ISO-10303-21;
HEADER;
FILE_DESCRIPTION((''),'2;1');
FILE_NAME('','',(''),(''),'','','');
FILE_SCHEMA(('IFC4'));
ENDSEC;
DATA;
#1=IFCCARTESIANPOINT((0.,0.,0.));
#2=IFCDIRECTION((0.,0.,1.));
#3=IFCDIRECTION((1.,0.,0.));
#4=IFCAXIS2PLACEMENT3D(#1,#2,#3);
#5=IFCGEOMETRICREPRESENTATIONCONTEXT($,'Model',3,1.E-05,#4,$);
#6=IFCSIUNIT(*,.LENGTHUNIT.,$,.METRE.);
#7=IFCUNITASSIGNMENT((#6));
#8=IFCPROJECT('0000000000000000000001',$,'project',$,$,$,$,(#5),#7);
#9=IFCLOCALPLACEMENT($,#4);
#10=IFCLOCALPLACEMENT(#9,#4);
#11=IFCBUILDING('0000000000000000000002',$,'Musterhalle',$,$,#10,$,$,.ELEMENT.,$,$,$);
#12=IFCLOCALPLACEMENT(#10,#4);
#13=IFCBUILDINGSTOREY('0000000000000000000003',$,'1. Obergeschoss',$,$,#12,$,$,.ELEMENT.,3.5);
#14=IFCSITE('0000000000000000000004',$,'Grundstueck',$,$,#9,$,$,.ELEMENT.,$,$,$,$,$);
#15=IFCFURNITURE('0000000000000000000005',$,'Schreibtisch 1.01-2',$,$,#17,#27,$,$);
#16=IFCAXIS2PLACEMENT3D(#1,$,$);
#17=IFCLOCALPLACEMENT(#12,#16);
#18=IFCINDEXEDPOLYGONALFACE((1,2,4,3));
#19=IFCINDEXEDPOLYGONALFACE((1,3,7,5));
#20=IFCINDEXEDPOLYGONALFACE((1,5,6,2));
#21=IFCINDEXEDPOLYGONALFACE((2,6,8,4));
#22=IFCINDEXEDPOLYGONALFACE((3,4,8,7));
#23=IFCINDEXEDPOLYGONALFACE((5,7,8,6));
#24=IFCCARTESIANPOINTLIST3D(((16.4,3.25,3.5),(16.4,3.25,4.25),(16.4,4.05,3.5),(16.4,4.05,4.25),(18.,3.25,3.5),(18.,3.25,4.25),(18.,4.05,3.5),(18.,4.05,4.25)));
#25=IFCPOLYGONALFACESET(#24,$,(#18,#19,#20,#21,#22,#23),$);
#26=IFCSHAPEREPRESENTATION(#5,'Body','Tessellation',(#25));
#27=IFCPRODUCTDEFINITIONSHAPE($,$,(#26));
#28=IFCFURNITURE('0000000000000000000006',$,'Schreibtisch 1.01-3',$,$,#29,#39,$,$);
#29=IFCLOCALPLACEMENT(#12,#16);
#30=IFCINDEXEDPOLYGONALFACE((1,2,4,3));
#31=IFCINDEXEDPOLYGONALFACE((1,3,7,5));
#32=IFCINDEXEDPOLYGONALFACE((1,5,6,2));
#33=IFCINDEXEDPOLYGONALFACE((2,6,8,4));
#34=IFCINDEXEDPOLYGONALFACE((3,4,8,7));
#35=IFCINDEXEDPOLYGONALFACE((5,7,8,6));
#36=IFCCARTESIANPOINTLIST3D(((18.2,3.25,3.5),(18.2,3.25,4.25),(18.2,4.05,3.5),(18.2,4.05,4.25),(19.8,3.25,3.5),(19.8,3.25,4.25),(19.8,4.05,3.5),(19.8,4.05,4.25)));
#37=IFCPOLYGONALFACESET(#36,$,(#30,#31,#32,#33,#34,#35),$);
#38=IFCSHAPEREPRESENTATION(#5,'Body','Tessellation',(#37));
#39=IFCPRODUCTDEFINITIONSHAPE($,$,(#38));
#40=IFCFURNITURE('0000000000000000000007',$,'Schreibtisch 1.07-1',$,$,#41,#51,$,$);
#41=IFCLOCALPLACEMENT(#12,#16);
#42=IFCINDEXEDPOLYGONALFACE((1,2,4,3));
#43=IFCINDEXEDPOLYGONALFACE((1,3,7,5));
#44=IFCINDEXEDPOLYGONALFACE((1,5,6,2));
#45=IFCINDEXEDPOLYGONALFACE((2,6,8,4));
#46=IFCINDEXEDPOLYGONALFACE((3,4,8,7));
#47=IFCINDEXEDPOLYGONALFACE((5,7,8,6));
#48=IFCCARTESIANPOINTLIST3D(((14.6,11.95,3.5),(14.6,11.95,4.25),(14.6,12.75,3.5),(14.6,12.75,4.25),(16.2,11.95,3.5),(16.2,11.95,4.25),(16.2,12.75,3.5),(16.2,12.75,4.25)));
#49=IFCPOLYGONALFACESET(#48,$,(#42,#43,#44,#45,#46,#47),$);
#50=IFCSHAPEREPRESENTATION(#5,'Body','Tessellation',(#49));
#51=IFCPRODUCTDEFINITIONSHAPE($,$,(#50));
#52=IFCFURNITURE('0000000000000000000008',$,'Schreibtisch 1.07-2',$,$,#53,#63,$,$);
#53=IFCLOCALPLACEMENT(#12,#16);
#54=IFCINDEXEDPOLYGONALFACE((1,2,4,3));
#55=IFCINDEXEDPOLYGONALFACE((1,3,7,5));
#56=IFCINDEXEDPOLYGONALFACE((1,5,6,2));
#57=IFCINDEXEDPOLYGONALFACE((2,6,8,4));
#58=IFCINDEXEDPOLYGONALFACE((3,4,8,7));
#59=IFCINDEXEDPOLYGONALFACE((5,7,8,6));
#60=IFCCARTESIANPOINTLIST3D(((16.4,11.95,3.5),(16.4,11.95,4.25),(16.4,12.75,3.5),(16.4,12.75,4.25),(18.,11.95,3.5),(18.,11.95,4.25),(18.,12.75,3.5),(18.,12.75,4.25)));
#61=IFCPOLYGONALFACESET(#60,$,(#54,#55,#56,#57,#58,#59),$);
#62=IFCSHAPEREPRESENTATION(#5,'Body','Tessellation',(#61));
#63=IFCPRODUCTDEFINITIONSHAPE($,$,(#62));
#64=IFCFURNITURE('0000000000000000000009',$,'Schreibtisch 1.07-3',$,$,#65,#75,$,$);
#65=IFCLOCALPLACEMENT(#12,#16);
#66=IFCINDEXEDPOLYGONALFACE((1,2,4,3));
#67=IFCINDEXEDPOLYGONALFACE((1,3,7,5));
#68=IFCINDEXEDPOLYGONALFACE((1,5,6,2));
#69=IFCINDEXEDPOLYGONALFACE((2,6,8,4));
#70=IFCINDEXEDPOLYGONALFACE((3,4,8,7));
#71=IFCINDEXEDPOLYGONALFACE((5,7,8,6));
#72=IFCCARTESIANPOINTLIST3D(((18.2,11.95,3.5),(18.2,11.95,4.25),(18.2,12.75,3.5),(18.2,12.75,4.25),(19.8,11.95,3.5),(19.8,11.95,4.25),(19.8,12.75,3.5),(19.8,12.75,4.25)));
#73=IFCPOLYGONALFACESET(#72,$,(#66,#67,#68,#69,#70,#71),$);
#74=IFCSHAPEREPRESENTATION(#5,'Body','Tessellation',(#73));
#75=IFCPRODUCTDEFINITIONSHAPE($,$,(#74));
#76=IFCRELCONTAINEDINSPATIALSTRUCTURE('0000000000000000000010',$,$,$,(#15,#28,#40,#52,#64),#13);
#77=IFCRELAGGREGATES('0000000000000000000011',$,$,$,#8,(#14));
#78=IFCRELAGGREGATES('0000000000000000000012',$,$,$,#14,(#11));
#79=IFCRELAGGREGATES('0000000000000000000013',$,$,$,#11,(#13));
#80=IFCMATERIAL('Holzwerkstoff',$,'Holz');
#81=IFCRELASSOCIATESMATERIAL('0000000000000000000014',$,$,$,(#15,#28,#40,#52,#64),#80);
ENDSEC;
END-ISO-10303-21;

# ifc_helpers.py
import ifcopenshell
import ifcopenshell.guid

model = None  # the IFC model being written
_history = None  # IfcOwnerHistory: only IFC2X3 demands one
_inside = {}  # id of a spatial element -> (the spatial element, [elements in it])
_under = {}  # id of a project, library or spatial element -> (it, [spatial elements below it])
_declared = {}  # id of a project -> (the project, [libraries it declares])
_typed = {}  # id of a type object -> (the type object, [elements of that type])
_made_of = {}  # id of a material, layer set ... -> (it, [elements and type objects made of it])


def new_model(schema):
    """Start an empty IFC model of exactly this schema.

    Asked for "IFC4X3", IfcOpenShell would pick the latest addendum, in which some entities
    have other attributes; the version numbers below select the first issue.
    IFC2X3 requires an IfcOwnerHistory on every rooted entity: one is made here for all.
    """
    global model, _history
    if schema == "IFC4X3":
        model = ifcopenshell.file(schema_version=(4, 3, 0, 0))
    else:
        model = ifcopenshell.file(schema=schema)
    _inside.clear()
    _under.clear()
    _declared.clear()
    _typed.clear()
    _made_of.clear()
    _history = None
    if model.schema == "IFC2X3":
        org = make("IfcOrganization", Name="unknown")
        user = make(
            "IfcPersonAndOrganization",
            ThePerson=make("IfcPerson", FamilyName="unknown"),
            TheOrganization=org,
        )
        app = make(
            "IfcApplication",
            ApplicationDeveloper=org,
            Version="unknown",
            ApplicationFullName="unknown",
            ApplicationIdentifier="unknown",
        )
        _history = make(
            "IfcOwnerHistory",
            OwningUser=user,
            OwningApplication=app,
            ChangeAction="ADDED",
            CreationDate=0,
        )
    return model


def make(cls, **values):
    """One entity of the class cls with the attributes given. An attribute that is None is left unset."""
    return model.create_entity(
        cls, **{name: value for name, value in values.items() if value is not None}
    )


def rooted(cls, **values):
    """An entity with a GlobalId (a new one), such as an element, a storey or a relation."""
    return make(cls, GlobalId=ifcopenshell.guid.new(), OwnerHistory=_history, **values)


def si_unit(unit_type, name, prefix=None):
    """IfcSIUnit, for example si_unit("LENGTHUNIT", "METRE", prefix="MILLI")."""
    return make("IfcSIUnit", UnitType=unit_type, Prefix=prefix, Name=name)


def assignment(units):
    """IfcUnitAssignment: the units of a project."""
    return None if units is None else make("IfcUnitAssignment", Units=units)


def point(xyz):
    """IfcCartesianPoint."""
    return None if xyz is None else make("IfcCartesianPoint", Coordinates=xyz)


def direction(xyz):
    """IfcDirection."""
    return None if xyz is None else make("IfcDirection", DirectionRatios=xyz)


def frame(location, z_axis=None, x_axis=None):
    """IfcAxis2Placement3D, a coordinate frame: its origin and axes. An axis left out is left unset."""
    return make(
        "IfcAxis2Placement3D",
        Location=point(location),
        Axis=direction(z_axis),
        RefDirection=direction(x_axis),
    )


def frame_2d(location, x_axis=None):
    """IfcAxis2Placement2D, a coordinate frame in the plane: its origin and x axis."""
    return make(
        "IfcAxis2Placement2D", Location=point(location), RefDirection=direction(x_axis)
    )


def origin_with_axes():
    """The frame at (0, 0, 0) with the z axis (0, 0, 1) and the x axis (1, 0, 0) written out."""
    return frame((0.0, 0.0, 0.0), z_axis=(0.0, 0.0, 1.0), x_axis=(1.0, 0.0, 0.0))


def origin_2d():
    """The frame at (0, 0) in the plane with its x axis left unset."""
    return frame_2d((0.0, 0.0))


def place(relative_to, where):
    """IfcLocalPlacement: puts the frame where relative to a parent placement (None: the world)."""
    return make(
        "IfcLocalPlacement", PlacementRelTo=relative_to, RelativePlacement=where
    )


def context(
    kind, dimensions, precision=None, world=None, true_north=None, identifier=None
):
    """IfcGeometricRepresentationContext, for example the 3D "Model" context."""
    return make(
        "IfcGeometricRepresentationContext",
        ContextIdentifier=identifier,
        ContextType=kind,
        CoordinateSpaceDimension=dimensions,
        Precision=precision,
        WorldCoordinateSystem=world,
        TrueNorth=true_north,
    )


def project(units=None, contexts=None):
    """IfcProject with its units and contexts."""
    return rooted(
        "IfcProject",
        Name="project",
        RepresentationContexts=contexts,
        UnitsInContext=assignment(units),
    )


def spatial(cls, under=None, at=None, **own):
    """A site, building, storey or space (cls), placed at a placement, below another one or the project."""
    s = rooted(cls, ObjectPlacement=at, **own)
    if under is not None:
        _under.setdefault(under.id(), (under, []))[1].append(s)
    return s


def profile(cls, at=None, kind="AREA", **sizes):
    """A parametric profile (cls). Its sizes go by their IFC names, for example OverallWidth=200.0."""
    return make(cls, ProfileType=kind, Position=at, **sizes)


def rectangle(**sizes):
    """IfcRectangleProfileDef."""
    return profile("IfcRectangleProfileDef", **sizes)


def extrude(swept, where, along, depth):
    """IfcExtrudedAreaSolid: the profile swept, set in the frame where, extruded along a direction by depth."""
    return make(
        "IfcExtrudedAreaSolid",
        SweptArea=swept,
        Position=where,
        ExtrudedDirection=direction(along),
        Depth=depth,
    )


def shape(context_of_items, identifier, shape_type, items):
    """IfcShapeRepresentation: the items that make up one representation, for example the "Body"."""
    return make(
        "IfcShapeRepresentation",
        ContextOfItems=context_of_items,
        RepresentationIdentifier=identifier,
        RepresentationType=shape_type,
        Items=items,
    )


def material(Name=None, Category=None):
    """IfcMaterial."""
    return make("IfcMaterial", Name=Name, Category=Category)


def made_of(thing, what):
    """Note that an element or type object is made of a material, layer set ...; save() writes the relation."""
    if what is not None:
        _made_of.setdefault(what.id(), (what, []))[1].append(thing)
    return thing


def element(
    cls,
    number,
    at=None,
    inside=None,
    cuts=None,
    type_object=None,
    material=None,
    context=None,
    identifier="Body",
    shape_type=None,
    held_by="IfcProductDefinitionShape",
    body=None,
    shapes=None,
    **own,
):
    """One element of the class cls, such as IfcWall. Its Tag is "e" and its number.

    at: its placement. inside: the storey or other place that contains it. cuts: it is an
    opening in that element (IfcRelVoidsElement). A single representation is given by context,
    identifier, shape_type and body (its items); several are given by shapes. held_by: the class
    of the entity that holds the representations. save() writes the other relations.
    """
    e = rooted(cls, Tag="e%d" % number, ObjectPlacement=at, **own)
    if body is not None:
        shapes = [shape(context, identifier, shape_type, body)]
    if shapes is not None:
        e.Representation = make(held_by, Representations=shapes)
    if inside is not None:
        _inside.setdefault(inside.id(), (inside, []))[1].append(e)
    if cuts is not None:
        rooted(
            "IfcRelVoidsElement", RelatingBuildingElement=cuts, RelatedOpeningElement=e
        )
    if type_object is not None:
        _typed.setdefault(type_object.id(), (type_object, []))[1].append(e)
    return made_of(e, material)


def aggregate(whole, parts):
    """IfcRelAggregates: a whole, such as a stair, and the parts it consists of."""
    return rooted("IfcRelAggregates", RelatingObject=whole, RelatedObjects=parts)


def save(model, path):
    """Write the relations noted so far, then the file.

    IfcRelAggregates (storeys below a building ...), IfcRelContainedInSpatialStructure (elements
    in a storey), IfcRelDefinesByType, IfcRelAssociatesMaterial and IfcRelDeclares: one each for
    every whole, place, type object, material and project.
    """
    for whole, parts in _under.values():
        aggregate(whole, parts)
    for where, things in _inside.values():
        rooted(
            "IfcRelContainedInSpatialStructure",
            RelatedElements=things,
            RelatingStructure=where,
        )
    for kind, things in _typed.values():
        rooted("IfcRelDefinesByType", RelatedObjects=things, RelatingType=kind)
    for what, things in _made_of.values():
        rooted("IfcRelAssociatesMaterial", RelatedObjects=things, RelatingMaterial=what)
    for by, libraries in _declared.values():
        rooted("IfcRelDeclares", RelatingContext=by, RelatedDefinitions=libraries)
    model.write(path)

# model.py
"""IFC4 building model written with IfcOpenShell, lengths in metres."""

from ifc_helpers import new_model, si_unit, frame, origin_with_axes, origin_2d, place, context, project, spatial, rectangle, extrude, material, element, save


model = new_model("IFC4")

# Units and contexts
model_context = context("Model", 3, precision=1e-05, world=origin_with_axes())
ifc_project = project(units=[si_unit("LENGTHUNIT", "METRE")], contexts=[model_context])

# Site, building, storey
site_placement = place(None, origin_with_axes())
site = spatial("IfcSite", under=ifc_project, at=site_placement, Name="Grundstueck", CompositionType="ELEMENT")
building_placement = place(site_placement, origin_with_axes())
building = spatial("IfcBuilding", under=site, at=building_placement, Name="Musterhalle", CompositionType="ELEMENT")
storey_placement = place(building_placement, origin_with_axes())
storey = spatial("IfcBuildingStorey", under=building, at=storey_placement, Name="1. Obergeschoss", CompositionType="ELEMENT", Elevation=3.5)

# Shared definitions
placement = place(storey_placement, origin_with_axes())

# Shared definitions
ifc_material_1 = material(Name="Holzwerkstoff", Category="Holz")

# Furniture
element("IfcFurniture", 1, at=placement, inside=storey, material=ifc_material_1, Name="Schreibtisch 1.01-2", context=model_context, shape_type="SweptSolid", body=[
    extrude(rectangle(XDim=1.6, YDim=0.8, at=origin_2d()), frame((17.2, 3.65, 3.5), z_axis=(0.0, 0.0, 1.0), x_axis=(1.0, 0.0, 0.0)), (0.0, 0.0, 1.0), 0.75),
])
element("IfcFurniture", 2, at=placement, inside=storey, material=ifc_material_1, Name="Schreibtisch 1.01-3", context=model_context, shape_type="SweptSolid", body=[
    extrude(rectangle(XDim=1.6, YDim=0.8, at=origin_2d()), frame((19.0, 3.65, 3.5), z_axis=(0.0, 0.0, 1.0), x_axis=(1.0, 0.0, 0.0)), (0.0, 0.0, 1.0), 0.75),
])
element("IfcFurniture", 3, at=placement, inside=storey, material=ifc_material_1, Name="Schreibtisch 1.07-1", context=model_context, shape_type="SweptSolid", body=[
    extrude(rectangle(XDim=1.6, YDim=0.8, at=origin_2d()), frame((15.4, 12.35, 3.5), z_axis=(0.0, 0.0, 1.0), x_axis=(1.0, 0.0, 0.0)), (0.0, 0.0, 1.0), 0.75),
])
element("IfcFurniture", 4, at=placement, inside=storey, material=ifc_material_1, Name="Schreibtisch 1.07-2", context=model_context, shape_type="SweptSolid", body=[
    extrude(rectangle(XDim=1.6, YDim=0.8, at=origin_2d()), frame((17.2, 12.35, 3.5), z_axis=(0.0, 0.0, 1.0), x_axis=(1.0, 0.0, 0.0)), (0.0, 0.0, 1.0), 0.75),
])
element("IfcFurniture", 5, at=placement, inside=storey, material=ifc_material_1, Name="Schreibtisch 1.07-3", context=model_context, shape_type="SweptSolid", body=[
    extrude(rectangle(XDim=1.6, YDim=0.8, at=origin_2d()), frame((19.0, 12.35, 3.5), z_axis=(0.0, 0.0, 1.0), x_axis=(1.0, 0.0, 0.0)), (0.0, 0.0, 1.0), 0.75),
])

save(model, "model.ifc")
